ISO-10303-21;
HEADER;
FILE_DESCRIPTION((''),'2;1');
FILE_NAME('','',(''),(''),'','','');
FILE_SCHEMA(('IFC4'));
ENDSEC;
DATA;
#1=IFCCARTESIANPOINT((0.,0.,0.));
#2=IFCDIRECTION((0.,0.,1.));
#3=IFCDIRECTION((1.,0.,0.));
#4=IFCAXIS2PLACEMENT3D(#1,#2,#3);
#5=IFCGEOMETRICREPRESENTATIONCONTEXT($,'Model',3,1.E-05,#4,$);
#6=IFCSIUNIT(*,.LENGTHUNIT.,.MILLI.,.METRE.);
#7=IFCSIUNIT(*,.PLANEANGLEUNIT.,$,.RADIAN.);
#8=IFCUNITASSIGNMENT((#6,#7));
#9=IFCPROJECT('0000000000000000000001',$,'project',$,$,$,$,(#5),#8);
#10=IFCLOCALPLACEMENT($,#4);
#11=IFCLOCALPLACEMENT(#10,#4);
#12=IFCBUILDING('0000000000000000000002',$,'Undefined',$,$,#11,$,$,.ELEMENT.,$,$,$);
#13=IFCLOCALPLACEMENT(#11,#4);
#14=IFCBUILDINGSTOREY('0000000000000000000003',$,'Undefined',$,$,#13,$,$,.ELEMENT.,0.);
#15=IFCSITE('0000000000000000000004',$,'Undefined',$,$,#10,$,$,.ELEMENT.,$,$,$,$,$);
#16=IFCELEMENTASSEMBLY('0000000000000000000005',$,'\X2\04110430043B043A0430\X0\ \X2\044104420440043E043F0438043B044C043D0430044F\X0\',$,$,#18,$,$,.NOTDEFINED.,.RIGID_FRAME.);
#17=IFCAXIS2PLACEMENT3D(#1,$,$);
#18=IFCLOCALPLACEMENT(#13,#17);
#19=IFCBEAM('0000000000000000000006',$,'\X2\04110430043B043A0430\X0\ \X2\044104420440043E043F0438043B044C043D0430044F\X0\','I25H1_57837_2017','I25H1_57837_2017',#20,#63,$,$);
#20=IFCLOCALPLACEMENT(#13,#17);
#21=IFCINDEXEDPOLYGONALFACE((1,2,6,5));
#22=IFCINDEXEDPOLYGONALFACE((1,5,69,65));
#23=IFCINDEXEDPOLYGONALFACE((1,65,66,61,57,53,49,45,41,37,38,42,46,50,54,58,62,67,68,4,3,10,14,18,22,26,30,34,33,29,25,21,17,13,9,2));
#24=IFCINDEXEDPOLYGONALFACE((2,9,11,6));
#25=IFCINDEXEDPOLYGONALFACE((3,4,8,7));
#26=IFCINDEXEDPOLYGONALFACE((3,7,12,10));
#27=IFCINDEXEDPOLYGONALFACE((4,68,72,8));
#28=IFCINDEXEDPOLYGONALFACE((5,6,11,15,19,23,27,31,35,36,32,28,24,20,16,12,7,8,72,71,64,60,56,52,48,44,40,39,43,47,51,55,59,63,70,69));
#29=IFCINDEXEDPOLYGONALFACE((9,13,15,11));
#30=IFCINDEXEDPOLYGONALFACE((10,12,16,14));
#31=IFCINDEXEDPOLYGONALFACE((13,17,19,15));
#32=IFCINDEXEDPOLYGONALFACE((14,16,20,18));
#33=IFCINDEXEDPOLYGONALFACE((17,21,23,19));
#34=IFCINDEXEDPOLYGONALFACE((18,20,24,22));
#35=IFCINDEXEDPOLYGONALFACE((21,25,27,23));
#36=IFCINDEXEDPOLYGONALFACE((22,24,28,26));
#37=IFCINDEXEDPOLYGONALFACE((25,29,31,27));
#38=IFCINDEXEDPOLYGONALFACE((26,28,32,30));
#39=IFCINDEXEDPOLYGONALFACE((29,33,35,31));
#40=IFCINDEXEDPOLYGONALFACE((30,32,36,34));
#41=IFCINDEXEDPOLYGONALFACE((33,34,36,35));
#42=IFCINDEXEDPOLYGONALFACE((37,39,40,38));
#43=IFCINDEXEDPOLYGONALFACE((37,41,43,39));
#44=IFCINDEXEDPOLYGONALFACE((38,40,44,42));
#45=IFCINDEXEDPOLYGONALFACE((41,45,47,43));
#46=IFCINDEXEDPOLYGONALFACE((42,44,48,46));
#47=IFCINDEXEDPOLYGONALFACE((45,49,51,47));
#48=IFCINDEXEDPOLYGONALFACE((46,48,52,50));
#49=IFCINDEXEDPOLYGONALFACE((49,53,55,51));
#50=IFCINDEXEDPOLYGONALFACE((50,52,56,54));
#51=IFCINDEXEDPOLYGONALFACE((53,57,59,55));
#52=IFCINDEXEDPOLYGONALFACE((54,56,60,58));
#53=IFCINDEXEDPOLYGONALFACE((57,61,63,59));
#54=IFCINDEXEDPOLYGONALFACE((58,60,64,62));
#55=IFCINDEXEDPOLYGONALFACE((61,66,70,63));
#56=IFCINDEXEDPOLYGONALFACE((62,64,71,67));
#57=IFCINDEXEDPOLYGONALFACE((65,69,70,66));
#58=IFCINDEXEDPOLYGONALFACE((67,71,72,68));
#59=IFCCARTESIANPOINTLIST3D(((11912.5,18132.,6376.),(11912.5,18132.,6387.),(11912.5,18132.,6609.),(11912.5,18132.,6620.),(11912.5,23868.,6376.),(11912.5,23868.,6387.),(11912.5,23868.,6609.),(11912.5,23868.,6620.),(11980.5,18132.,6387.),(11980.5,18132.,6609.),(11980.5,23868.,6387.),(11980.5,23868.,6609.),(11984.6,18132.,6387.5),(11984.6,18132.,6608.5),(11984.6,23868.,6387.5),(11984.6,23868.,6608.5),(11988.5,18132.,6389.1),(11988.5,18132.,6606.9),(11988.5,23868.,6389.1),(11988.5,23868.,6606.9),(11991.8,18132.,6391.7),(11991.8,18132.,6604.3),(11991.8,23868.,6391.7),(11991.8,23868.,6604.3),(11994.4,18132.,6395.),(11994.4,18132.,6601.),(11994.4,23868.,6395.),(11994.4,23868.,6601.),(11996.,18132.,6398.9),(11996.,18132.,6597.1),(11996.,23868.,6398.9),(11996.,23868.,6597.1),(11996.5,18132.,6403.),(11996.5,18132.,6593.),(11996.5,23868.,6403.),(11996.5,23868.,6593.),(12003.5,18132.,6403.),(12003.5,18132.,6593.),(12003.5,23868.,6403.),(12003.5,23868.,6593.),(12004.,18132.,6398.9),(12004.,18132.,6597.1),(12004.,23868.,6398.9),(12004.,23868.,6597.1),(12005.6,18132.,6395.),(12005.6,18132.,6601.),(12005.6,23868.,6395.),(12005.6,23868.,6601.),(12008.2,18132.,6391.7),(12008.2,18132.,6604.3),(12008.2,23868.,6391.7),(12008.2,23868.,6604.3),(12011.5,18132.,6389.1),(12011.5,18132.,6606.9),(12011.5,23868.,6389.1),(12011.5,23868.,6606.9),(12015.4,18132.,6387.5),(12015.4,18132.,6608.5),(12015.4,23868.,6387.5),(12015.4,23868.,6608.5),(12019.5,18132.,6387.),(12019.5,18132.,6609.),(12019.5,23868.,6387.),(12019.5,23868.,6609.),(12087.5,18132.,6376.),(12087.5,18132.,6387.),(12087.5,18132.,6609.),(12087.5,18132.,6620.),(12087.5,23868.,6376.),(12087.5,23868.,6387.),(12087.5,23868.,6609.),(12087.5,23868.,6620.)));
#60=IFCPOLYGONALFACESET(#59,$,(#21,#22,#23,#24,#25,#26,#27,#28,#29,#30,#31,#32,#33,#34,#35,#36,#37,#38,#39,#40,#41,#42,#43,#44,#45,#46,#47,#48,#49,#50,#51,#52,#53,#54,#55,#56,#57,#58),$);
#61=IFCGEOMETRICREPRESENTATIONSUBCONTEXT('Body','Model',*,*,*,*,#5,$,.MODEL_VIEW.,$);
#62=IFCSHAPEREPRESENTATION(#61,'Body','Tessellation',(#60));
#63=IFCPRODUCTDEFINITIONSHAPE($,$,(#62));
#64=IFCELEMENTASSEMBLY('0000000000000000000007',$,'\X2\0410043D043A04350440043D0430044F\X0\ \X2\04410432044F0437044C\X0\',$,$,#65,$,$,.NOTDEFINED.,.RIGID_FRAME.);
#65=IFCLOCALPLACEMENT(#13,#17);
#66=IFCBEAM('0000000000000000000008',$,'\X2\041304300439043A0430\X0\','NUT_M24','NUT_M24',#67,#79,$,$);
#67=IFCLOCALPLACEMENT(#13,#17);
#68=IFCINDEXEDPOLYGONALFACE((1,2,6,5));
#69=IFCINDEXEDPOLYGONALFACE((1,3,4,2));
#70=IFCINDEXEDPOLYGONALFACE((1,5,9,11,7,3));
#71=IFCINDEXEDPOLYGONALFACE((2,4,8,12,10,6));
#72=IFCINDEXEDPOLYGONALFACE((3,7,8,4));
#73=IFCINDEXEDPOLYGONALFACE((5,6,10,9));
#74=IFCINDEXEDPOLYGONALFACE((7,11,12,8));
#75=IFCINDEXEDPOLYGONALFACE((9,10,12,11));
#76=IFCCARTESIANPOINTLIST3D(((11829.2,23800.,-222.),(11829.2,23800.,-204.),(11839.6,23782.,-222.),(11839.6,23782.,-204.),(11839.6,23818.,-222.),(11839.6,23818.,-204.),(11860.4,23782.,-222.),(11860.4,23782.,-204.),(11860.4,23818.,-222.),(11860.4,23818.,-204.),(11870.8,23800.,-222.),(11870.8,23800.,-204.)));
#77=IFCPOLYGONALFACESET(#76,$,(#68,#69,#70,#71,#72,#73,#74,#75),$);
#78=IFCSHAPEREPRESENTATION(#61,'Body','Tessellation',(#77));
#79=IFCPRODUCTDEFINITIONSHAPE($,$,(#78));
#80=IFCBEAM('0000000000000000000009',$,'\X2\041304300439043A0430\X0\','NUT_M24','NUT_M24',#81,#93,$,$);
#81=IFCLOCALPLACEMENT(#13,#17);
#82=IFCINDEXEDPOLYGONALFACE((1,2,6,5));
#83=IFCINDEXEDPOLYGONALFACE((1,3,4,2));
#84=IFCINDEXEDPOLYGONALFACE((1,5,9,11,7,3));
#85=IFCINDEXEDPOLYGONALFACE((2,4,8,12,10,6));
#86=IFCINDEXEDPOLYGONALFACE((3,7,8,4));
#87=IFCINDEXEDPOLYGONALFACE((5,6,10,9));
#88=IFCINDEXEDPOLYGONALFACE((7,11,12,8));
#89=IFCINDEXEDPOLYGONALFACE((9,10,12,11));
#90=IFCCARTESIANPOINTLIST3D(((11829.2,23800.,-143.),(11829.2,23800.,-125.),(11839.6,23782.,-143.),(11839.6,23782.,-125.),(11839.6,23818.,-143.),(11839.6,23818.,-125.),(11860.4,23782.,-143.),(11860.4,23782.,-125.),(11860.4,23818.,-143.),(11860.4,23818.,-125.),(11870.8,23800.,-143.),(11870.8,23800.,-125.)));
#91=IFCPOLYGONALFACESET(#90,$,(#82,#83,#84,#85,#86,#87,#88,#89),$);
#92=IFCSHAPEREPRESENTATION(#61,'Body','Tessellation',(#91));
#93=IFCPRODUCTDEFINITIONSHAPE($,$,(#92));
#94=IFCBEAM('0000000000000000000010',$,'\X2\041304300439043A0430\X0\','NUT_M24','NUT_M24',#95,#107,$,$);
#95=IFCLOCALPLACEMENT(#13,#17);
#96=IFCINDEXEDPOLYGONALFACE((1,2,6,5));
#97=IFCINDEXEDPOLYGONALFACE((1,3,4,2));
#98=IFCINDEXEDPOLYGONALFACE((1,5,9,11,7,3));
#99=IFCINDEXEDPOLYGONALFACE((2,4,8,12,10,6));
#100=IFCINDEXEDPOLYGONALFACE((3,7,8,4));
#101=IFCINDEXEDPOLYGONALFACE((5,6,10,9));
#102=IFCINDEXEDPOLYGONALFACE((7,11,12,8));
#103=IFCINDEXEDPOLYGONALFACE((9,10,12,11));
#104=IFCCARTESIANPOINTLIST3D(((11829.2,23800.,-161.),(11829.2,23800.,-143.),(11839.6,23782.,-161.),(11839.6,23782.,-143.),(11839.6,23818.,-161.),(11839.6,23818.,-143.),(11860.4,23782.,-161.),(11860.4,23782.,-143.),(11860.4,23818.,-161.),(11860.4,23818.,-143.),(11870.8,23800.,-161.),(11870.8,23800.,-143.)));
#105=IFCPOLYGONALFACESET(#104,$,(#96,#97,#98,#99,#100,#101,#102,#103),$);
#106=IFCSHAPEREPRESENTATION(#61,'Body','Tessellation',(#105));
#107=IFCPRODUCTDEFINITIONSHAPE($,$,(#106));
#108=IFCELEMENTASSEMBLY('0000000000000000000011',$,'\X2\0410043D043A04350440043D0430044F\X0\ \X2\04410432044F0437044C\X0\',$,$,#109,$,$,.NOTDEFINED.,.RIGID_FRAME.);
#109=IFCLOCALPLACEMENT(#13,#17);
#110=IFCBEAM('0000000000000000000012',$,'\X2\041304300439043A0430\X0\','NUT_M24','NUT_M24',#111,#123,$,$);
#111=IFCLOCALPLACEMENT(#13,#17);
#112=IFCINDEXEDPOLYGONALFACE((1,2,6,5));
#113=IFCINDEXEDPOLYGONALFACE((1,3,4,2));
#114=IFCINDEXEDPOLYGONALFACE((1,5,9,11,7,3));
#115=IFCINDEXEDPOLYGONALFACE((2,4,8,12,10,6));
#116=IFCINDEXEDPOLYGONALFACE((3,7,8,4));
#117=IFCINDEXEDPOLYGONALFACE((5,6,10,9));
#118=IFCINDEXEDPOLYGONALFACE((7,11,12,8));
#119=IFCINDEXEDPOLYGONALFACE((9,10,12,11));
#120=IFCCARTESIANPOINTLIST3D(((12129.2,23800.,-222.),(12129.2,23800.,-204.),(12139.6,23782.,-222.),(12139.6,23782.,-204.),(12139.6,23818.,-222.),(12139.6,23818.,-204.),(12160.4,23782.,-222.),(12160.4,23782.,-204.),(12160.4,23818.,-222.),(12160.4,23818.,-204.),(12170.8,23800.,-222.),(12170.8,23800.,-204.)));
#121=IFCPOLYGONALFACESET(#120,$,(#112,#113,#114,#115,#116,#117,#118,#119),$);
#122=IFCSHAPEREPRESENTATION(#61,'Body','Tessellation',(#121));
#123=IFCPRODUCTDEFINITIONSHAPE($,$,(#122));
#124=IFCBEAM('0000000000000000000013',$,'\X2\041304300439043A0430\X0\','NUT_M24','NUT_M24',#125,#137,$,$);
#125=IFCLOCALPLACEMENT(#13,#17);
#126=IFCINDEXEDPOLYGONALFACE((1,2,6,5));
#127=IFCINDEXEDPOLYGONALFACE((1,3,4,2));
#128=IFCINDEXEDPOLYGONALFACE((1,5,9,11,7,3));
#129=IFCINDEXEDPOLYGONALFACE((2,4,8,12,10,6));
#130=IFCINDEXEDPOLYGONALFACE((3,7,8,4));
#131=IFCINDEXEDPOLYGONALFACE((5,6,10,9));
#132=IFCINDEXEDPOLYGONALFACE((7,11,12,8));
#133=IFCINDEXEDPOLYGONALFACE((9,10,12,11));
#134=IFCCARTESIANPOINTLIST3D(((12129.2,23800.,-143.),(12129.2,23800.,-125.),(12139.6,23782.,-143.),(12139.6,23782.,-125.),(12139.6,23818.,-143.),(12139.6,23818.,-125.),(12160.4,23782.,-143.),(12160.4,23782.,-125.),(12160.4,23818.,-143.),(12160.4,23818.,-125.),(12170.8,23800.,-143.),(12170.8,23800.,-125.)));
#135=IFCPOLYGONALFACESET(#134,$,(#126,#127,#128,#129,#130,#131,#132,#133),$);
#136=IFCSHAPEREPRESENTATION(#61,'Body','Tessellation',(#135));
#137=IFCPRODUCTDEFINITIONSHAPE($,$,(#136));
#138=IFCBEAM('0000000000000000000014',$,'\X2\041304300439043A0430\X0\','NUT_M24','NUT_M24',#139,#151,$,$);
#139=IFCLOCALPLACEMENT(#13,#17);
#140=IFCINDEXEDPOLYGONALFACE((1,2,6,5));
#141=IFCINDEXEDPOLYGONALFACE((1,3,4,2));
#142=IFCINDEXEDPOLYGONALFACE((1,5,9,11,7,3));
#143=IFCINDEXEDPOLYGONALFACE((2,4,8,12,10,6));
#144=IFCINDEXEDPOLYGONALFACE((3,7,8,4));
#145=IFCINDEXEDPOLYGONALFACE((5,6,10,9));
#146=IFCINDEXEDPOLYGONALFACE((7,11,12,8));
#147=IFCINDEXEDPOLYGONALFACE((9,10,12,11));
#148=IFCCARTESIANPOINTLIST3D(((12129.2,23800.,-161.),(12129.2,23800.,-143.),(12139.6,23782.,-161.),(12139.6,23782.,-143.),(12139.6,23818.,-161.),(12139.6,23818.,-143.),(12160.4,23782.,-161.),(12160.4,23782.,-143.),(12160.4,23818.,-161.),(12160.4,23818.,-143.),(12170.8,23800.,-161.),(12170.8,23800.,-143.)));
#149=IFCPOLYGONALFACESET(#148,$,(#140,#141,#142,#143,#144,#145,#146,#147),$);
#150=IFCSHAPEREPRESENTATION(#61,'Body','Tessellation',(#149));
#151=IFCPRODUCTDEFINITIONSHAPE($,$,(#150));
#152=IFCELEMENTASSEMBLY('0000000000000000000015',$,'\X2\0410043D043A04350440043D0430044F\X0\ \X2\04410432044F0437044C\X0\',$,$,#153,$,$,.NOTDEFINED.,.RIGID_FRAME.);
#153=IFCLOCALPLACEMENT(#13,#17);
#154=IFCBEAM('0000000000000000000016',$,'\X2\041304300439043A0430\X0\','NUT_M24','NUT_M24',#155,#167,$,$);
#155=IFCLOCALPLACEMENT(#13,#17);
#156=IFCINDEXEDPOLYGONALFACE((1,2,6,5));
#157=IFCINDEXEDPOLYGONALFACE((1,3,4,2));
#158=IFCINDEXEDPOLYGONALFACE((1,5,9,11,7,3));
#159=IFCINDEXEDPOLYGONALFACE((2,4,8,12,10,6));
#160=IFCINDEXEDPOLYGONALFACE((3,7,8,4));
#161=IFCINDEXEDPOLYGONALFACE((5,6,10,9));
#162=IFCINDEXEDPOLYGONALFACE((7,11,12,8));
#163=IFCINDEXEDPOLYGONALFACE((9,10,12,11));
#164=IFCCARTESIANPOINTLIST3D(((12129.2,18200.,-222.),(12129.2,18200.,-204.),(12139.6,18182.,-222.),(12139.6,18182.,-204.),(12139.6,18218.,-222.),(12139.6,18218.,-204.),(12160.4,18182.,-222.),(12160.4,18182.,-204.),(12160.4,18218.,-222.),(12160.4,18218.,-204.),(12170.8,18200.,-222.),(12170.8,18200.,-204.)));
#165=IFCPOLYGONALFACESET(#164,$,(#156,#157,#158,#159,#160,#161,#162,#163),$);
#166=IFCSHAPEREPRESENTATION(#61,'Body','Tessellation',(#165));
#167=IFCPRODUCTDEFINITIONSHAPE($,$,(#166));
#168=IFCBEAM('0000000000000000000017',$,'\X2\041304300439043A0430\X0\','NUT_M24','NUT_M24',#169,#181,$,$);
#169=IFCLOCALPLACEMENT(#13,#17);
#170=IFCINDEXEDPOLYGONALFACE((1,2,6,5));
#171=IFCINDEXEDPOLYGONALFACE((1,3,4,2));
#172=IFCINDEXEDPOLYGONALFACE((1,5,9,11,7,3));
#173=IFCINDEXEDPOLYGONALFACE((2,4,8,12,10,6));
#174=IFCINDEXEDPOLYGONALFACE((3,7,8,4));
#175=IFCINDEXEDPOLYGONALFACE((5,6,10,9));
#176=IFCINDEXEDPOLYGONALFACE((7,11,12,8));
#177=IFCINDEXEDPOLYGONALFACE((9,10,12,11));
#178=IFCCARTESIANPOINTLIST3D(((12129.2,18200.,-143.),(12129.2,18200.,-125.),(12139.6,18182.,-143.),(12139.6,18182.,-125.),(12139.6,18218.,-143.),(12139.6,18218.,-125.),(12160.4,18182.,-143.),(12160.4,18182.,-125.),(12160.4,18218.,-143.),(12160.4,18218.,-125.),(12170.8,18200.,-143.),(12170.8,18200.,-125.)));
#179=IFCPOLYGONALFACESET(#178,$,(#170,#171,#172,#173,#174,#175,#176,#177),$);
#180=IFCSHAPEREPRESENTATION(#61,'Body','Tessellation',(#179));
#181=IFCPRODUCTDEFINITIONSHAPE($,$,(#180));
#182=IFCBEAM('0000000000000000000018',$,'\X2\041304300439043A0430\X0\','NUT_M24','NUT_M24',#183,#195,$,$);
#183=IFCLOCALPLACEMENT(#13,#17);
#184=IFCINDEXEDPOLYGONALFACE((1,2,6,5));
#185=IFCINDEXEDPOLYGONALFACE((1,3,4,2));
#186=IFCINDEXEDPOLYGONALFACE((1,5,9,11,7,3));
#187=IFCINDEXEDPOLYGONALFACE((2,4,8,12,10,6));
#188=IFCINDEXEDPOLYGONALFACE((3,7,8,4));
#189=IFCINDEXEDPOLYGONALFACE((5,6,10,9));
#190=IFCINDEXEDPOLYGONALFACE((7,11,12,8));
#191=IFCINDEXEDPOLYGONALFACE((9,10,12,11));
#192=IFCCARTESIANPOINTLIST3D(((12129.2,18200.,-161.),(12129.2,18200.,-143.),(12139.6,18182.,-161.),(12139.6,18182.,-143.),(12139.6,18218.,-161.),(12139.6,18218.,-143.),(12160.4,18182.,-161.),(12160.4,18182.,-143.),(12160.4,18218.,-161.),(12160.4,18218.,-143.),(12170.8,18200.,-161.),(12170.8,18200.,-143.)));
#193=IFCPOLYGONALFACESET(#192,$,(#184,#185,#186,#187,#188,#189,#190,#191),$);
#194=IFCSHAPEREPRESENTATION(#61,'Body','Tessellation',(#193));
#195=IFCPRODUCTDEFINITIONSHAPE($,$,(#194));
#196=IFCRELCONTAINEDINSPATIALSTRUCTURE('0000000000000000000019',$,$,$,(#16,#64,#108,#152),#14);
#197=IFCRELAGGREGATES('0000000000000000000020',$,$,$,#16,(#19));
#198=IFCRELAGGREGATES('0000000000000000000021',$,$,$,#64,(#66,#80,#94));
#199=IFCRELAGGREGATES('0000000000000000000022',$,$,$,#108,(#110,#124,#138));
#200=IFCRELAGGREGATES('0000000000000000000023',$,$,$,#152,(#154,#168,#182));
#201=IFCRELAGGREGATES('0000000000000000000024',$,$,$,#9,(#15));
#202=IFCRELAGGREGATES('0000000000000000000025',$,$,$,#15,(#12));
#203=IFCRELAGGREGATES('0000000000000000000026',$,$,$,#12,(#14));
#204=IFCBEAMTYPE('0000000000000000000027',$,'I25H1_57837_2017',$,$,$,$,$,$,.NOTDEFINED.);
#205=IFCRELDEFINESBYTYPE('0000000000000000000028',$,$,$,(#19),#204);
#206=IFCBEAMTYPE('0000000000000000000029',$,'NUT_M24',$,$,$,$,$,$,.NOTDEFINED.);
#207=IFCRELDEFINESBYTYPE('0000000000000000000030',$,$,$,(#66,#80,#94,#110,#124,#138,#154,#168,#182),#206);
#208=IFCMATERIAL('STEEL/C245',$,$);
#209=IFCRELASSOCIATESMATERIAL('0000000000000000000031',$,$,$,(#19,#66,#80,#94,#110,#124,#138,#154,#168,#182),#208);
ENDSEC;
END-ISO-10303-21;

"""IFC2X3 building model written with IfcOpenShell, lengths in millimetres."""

from ifc_helpers import new_model, si_unit, frame, origin_with_axes, origin_2d_with_axis, place, context, subcontext, project, spatial, polyline, i_section, outline, extrude, material, type_object, element, aggregate, save


model = new_model("IFC2X3")

# Units and contexts
model_context = context("Model", 3, precision=1e-05, world=origin_with_axes())
body_context = subcontext(model_context, "Body", "Model", "MODEL_VIEW")
ifc_project = project(units=[si_unit("LENGTHUNIT", "METRE", prefix="MILLI"), si_unit("PLANEANGLEUNIT", "RADIAN")], contexts=[model_context])

# Site, building, storey
site_placement = place(None, origin_with_axes())
site = spatial("IfcSite", under=ifc_project, at=site_placement, Name="Undefined", CompositionType="ELEMENT")
building_placement = place(site_placement, origin_with_axes())
building = spatial("IfcBuilding", under=site, at=building_placement, Name="Undefined", CompositionType="ELEMENT")
storey_placement = place(building_placement, origin_with_axes())
storey = spatial("IfcBuildingStorey", under=building, at=storey_placement, Name="Undefined", CompositionType="ELEMENT", Elevation=0.0)

# Element assembly, beam
assembly_1_placement = place(storey_placement, origin_with_axes())
assembly_1 = element("IfcElementAssembly", 1, at=assembly_1_placement, inside=storey, Name="Балка стропильная", AssemblyPlace="NOTDEFINED", PredefinedType="RIGID_FRAME")
ifc_material_1 = material(Name="STEEL/C245")
beam_type_1 = type_object("IfcBeamType", Name="I25H1_57837_2017", PredefinedType="NOTDEFINED")
beam_1_placement = place(assembly_1_placement, frame((12000.0, 23868.0, 6498.0), z_axis=(0.0, 0.0, 1.0), x_axis=(0.0, -1.0, 0.0)))
beam_1 = element("IfcBeam", 2, at=beam_1_placement, type_object=beam_type_1, material=ifc_material_1, Name="Балка стропильная", Description="I25H1_57837_2017", ObjectType="I25H1_57837_2017", context=body_context, shape_type="SweptSolid", body=[
    extrude(i_section(OverallWidth=175.0, OverallDepth=244.0, WebThickness=7.0, FlangeThickness=11.0, FilletRadius=16.0, at=origin_2d_with_axis()), frame((5736.0, 0.0, 0.0), z_axis=(-1.0, 0.0, 0.0), x_axis=(0.0, -1.0, 0.0)), (0.0, 0.0, 1.0), 5736.0),
])

# Element assemblies, beams
assembly_2_placement = place(storey_placement, origin_with_axes())
assembly_2 = element("IfcElementAssembly", 3, at=assembly_2_placement, inside=storey, Name="Анкерная связь", AssemblyPlace="NOTDEFINED", PredefinedType="RIGID_FRAME")
beam_type_2 = type_object("IfcBeamType", Name="NUT_M24", PredefinedType="NOTDEFINED")
beam_2_placement = place(assembly_2_placement, frame((11850.0, 23800.0, -204.0), z_axis=(0.0, -1.0, 0.0), x_axis=(0.0, 0.0, -1.0)))
beam_2 = element("IfcBeam", 4, at=beam_2_placement, type_object=beam_type_2, material=ifc_material_1, Name="Гайка", Description="NUT_M24", ObjectType="NUT_M24", context=body_context, shape_type="SweptSolid", body=[
    extrude(outline(polyline([(-10.4, 18.0), (10.4, 18.0), (20.8, 0.0), (10.4, -18.0), (-10.4, -18.0), (-20.8, 0.0), (-10.4, 18.0)])), frame((18.0, 0.0, 0.0), z_axis=(-1.0, 0.0, 0.0), x_axis=(0.0, -1.0, 0.0)), (0.0, 0.0, 1.0), 18.0),
])
beam_3_placement = place(assembly_2_placement, frame((11850.0, 23800.0, -125.0), z_axis=(0.0, -1.0, 0.0), x_axis=(0.0, 0.0, -1.0)))
beam_3 = element("IfcBeam", 5, at=beam_3_placement, type_object=beam_type_2, material=ifc_material_1, Name="Гайка", Description="NUT_M24", ObjectType="NUT_M24", context=body_context, shape_type="SweptSolid", body=[
    extrude(outline(polyline([(-10.4, 18.0), (10.4, 18.0), (20.8, 0.0), (10.4, -18.0), (-10.4, -18.0), (-20.8, 0.0), (-10.4, 18.0)])), frame((18.0, 0.0, 0.0), z_axis=(-1.0, 0.0, 0.0), x_axis=(0.0, -1.0, 0.0)), (0.0, 0.0, 1.0), 18.0),
])
beam_4_placement = place(assembly_2_placement, frame((11850.0, 23800.0, -143.0), z_axis=(0.0, -1.0, 0.0), x_axis=(0.0, 0.0, -1.0)))
beam_4 = element("IfcBeam", 6, at=beam_4_placement, type_object=beam_type_2, material=ifc_material_1, Name="Гайка", Description="NUT_M24", ObjectType="NUT_M24", context=body_context, shape_type="SweptSolid", body=[
    extrude(outline(polyline([(-10.4, 18.0), (10.4, 18.0), (20.8, 0.0), (10.4, -18.0), (-10.4, -18.0), (-20.8, 0.0), (-10.4, 18.0)])), frame((18.0, 0.0, 0.0), z_axis=(-1.0, 0.0, 0.0), x_axis=(0.0, -1.0, 0.0)), (0.0, 0.0, 1.0), 18.0),
])
assembly_3_placement = place(storey_placement, origin_with_axes())
assembly_3 = element("IfcElementAssembly", 7, at=assembly_3_placement, inside=storey, Name="Анкерная связь", AssemblyPlace="NOTDEFINED", PredefinedType="RIGID_FRAME")
beam_5_placement = place(assembly_3_placement, frame((12150.0, 23800.0, -204.0), z_axis=(0.0, 1.0, 0.0), x_axis=(0.0, 0.0, -1.0)))
beam_5 = element("IfcBeam", 8, at=beam_5_placement, type_object=beam_type_2, material=ifc_material_1, Name="Гайка", Description="NUT_M24", ObjectType="NUT_M24", context=body_context, shape_type="SweptSolid", body=[
    extrude(outline(polyline([(-10.4, 18.0), (10.4, 18.0), (20.8, 0.0), (10.4, -18.0), (-10.4, -18.0), (-20.8, 0.0), (-10.4, 18.0)])), frame((18.0, 0.0, 0.0), z_axis=(-1.0, 0.0, 0.0), x_axis=(0.0, -1.0, 0.0)), (0.0, 0.0, 1.0), 18.0),
])
beam_6_placement = place(assembly_3_placement, frame((12150.0, 23800.0, -125.0), z_axis=(0.0, 1.0, 0.0), x_axis=(0.0, 0.0, -1.0)))
beam_6 = element("IfcBeam", 9, at=beam_6_placement, type_object=beam_type_2, material=ifc_material_1, Name="Гайка", Description="NUT_M24", ObjectType="NUT_M24", context=body_context, shape_type="SweptSolid", body=[
    extrude(outline(polyline([(-10.4, 18.0), (10.4, 18.0), (20.8, 0.0), (10.4, -18.0), (-10.4, -18.0), (-20.8, 0.0), (-10.4, 18.0)])), frame((18.0, 0.0, 0.0), z_axis=(-1.0, 0.0, 0.0), x_axis=(0.0, -1.0, 0.0)), (0.0, 0.0, 1.0), 18.0),
])
beam_7_placement = place(assembly_3_placement, frame((12150.0, 23800.0, -143.0), z_axis=(0.0, 1.0, 0.0), x_axis=(0.0, 0.0, -1.0)))
beam_7 = element("IfcBeam", 10, at=beam_7_placement, type_object=beam_type_2, material=ifc_material_1, Name="Гайка", Description="NUT_M24", ObjectType="NUT_M24", context=body_context, shape_type="SweptSolid", body=[
    extrude(outline(polyline([(-10.4, 18.0), (10.4, 18.0), (20.8, 0.0), (10.4, -18.0), (-10.4, -18.0), (-20.8, 0.0), (-10.4, 18.0)])), frame((18.0, 0.0, 0.0), z_axis=(-1.0, 0.0, 0.0), x_axis=(0.0, -1.0, 0.0)), (0.0, 0.0, 1.0), 18.0),
])
assembly_4_placement = place(storey_placement, origin_with_axes())
assembly_4 = element("IfcElementAssembly", 11, at=assembly_4_placement, inside=storey, Name="Анкерная связь", AssemblyPlace="NOTDEFINED", PredefinedType="RIGID_FRAME")
beam_8_placement = place(assembly_4_placement, frame((12150.0, 18200.0, -204.0), z_axis=(0.0, 1.0, 0.0), x_axis=(0.0, 0.0, -1.0)))
beam_8 = element("IfcBeam", 12, at=beam_8_placement, type_object=beam_type_2, material=ifc_material_1, Name="Гайка", Description="NUT_M24", ObjectType="NUT_M24", context=body_context, shape_type="SweptSolid", body=[
    extrude(outline(polyline([(-10.4, 18.0), (10.4, 18.0), (20.8, 0.0), (10.4, -18.0), (-10.4, -18.0), (-20.8, 0.0), (-10.4, 18.0)])), frame((18.0, 0.0, 0.0), z_axis=(-1.0, 0.0, 0.0), x_axis=(0.0, -1.0, 0.0)), (0.0, 0.0, 1.0), 18.0),
])
beam_9_placement = place(assembly_4_placement, frame((12150.0, 18200.0, -125.0), z_axis=(0.0, 1.0, 0.0), x_axis=(0.0, 0.0, -1.0)))
beam_9 = element("IfcBeam", 13, at=beam_9_placement, type_object=beam_type_2, material=ifc_material_1, Name="Гайка", Description="NUT_M24", ObjectType="NUT_M24", context=body_context, shape_type="SweptSolid", body=[
    extrude(outline(polyline([(-10.4, 18.0), (10.4, 18.0), (20.8, 0.0), (10.4, -18.0), (-10.4, -18.0), (-20.8, 0.0), (-10.4, 18.0)])), frame((18.0, 0.0, 0.0), z_axis=(-1.0, 0.0, 0.0), x_axis=(0.0, -1.0, 0.0)), (0.0, 0.0, 1.0), 18.0),
])
beam_10_placement = place(assembly_4_placement, frame((12150.0, 18200.0, -143.0), z_axis=(0.0, 1.0, 0.0), x_axis=(0.0, 0.0, -1.0)))
beam_10 = element("IfcBeam", 14, at=beam_10_placement, type_object=beam_type_2, material=ifc_material_1, Name="Гайка", Description="NUT_M24", ObjectType="NUT_M24", context=body_context, shape_type="SweptSolid", body=[
    extrude(outline(polyline([(-10.4, 18.0), (10.4, 18.0), (20.8, 0.0), (10.4, -18.0), (-10.4, -18.0), (-20.8, 0.0), (-10.4, 18.0)])), frame((18.0, 0.0, 0.0), z_axis=(-1.0, 0.0, 0.0), x_axis=(0.0, -1.0, 0.0)), (0.0, 0.0, 1.0), 18.0),
])

aggregate(assembly_1, [beam_1])
aggregate(assembly_2, [beam_2, beam_3, beam_4])
aggregate(assembly_3, [beam_5, beam_6, beam_7])
aggregate(assembly_4, [beam_8, beam_9, beam_10])

save(model, "model.ifc")
